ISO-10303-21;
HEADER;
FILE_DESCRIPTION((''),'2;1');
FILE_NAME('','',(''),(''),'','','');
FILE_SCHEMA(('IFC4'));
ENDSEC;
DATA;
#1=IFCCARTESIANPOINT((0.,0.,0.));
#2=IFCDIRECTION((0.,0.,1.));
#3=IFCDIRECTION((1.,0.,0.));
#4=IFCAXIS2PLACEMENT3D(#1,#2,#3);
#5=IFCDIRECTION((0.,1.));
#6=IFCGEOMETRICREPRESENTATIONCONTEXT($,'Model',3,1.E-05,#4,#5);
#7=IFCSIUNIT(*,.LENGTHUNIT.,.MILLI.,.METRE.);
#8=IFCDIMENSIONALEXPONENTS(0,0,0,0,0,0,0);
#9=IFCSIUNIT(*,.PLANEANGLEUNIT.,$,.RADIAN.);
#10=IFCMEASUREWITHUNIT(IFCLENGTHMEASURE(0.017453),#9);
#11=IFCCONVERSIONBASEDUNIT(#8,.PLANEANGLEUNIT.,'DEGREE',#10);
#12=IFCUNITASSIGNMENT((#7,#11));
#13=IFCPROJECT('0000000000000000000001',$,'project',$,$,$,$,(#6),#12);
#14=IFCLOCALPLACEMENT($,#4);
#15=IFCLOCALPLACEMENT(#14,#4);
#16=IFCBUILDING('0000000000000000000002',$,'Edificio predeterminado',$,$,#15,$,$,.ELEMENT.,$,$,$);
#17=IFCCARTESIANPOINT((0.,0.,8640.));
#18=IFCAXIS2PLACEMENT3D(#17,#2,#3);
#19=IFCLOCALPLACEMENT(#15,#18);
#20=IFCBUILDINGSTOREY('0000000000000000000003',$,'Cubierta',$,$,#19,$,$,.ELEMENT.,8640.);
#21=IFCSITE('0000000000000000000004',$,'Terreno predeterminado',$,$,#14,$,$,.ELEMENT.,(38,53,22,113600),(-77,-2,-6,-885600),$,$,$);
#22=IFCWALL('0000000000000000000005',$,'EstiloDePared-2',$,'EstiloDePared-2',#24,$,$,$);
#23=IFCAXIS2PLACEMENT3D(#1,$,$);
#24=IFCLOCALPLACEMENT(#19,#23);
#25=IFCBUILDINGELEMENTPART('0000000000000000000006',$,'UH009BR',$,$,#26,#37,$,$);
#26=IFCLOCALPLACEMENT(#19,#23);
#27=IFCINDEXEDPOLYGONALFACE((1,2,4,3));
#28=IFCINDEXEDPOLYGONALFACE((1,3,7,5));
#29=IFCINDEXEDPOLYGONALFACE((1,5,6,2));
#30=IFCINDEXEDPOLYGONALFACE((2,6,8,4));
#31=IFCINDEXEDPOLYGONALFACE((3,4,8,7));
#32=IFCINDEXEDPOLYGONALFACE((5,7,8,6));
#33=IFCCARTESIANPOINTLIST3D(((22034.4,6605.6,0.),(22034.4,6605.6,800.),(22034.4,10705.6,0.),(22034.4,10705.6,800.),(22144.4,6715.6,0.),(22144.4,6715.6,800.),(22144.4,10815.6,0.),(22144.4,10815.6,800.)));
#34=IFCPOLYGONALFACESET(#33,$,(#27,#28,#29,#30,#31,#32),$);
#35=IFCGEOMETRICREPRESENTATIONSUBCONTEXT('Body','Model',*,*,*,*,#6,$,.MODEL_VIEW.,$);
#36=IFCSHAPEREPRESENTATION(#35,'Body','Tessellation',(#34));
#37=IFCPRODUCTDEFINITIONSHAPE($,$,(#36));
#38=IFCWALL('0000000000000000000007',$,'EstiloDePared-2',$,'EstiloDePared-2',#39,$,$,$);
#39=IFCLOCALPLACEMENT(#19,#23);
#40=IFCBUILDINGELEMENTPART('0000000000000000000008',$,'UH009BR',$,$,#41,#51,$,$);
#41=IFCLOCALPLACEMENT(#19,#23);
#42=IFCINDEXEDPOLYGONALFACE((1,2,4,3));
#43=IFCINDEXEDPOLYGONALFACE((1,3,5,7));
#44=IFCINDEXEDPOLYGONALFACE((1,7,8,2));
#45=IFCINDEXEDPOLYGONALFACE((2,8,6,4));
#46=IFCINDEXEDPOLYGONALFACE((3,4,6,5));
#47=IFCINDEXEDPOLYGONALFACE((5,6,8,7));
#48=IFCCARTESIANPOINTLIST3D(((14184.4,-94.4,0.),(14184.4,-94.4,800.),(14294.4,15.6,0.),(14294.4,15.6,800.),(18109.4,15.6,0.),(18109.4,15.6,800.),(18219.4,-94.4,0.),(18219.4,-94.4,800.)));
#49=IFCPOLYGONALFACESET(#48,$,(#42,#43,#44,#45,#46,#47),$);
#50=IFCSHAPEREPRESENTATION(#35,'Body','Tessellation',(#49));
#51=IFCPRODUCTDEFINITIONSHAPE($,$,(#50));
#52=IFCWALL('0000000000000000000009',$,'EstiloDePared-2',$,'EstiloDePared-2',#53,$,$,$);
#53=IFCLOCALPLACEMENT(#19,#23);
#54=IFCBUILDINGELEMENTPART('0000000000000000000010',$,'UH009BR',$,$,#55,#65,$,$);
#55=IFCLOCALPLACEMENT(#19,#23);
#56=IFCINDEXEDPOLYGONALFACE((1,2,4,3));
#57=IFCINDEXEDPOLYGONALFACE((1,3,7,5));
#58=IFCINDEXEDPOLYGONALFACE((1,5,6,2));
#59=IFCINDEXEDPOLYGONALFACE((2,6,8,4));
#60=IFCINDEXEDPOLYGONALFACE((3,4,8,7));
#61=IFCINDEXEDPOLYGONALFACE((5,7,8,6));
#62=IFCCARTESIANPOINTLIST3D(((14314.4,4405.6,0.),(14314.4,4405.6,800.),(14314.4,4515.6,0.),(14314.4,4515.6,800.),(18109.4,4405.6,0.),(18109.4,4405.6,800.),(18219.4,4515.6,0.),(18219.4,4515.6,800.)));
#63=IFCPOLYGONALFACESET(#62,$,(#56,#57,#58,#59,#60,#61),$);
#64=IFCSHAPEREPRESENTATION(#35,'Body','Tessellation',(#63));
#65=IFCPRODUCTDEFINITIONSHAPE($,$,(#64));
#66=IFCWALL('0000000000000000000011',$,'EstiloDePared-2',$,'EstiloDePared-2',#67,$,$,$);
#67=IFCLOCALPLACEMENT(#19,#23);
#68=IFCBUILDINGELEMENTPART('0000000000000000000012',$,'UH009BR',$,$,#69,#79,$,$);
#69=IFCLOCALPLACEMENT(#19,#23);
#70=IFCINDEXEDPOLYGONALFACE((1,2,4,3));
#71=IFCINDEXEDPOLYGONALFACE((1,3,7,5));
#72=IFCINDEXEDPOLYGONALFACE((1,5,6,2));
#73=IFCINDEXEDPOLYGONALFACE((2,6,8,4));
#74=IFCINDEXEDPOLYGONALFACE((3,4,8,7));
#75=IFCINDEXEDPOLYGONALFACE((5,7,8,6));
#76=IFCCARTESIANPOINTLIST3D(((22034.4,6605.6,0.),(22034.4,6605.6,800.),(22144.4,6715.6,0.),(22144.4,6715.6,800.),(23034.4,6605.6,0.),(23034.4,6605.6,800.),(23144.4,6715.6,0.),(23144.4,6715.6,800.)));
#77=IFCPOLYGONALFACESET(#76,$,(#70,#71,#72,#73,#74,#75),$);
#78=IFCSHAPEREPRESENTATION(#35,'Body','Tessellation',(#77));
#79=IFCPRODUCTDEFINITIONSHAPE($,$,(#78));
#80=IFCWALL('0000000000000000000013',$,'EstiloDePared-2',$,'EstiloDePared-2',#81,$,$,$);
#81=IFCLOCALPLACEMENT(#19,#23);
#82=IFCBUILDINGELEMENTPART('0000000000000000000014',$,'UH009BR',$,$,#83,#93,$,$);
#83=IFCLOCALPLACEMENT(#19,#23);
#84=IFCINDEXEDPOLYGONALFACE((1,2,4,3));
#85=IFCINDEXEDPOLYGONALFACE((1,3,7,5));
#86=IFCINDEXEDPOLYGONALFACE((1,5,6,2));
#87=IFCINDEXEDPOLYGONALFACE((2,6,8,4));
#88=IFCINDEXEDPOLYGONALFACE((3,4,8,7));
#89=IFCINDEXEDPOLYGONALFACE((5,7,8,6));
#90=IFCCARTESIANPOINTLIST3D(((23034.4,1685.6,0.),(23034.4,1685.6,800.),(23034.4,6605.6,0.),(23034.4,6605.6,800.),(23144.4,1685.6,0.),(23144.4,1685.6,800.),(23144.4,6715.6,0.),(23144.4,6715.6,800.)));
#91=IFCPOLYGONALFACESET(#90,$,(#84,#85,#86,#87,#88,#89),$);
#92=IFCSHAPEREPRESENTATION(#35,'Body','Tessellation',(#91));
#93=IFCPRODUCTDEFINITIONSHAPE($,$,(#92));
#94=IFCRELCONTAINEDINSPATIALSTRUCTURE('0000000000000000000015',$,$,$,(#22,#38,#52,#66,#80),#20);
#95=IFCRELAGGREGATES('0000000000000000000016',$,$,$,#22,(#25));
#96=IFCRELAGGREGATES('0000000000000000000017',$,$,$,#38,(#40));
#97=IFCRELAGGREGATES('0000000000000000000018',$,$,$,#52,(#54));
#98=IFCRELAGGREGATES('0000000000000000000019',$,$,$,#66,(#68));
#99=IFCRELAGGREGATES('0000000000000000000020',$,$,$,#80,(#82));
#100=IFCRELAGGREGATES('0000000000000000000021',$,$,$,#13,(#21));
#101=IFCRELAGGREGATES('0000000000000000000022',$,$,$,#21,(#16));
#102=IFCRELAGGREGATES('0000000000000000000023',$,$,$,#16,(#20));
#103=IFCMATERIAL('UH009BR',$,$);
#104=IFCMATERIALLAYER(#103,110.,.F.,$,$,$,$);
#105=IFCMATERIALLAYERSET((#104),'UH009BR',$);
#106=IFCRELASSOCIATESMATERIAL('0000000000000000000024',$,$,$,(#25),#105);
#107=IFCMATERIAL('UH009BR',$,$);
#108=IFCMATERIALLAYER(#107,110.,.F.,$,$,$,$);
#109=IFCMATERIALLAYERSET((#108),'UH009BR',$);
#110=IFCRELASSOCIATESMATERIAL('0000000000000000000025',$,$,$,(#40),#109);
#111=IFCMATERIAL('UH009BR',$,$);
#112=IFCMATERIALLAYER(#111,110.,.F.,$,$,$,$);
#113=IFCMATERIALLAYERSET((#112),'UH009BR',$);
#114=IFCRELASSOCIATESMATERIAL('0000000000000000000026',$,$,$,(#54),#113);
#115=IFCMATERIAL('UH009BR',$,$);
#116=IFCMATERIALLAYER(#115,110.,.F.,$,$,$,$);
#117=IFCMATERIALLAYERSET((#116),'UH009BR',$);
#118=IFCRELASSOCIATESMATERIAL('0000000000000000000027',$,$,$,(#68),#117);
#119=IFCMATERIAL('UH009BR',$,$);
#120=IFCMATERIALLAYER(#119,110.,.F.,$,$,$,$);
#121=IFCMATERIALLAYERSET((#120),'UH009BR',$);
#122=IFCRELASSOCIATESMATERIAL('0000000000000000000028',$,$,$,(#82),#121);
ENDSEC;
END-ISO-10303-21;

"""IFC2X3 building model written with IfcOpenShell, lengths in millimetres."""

from ifc_helpers import new_model, entity, si_unit, converted_unit, direction, frame, origin_with_axes, place, context, subcontext, project, spatial, polyline, outline, extrude, material, layer, layer_set, layer_usage, element, aggregate, save


model = new_model("IFC2X3")

# Units and contexts
model_context = context("Model", 3, precision=1e-05, world=origin_with_axes(), true_north=direction((0.0, 1.0)))
body_context = subcontext(model_context, "Body", "Model", "MODEL_VIEW")
ifc_project = project(units=[si_unit("LENGTHUNIT", "METRE", prefix="MILLI"), converted_unit("PLANEANGLEUNIT", "DEGREE", entity("IfcLengthMeasure", 0.017453), si_unit("PLANEANGLEUNIT", "RADIAN"), dimensions=[0, 0, 0, 0, 0, 0, 0])], contexts=[model_context])

# Site, building, storey
site_placement = place(None, origin_with_axes())
site = spatial("IfcSite", under=ifc_project, at=site_placement, Name="Terreno predeterminado", CompositionType="ELEMENT", RefLatitude=(38, 53, 22, 113600), RefLongitude=(-77, -2, -6, -885600))
building_placement = place(site_placement, origin_with_axes())
building = spatial("IfcBuilding", under=site, at=building_placement, Name="Edificio predeterminado", CompositionType="ELEMENT")
storey_placement = place(building_placement, frame((0.0, 0.0, 8640.0), z_axis=(0.0, 0.0, 1.0), x_axis=(1.0, 0.0, 0.0)))
storey = spatial("IfcBuildingStorey", under=building, at=storey_placement, Name="Cubierta", CompositionType="ELEMENT", Elevation=8640.0)

# Wall, building element part
wall_1_placement = place(storey_placement, frame((22089.4, 10760.6, 0.0), z_axis=(0.0, 0.0, 1.0), x_axis=(0.0, -1.0, 0.0)))
wall_1 = element("IfcWall", 1, at=wall_1_placement, inside=storey, Name="EstiloDePared-2", ObjectType="EstiloDePared-2")
ifc_material_1 = material(Name="UH009BR")
ifc_layer_1 = layer(ifc_material_1, 110.0, ventilated=False)
ifc_layer_set_1 = layer_set([ifc_layer_1], Name="UH009BR")
ifc_layer_usage_1 = layer_usage(ifc_layer_set_1, "AXIS2", "NEGATIVE", -55.0)
building_element_part_1_placement = place(wall_1_placement, origin_with_axes())
building_element_part_1 = element("IfcBuildingElementPart", 2, at=building_element_part_1_placement, material=ifc_layer_usage_1, Name="UH009BR", context=body_context, shape_type="SweptSolid", body=[
    extrude(outline(polyline([(4045.0, 55.0), (4155.0, -55.0), (55.0, -55.0), (-55.0, 55.0), (4045.0, 55.0)])), origin_with_axes(), (0.0, 0.0, 1.0), 800.0),
])
aggregate(wall_1, [building_element_part_1])

# Walls, building element parts
wall_2_placement = place(storey_placement, frame((18164.4, -39.4, 0.0), z_axis=(0.0, 0.0, 1.0), x_axis=(-1.0, 0.0, 0.0)))
wall_2 = element("IfcWall", 3, at=wall_2_placement, inside=storey, Name="EstiloDePared-2", ObjectType="EstiloDePared-2")
ifc_material_2 = material(Name="UH009BR")
ifc_layer_2 = layer(ifc_material_2, 110.0, ventilated=False)
ifc_layer_set_2 = layer_set([ifc_layer_2], Name="UH009BR")
ifc_layer_usage_2 = layer_usage(ifc_layer_set_2, "AXIS2", "NEGATIVE", -55.0)
building_element_part_2_placement = place(wall_2_placement, origin_with_axes())
building_element_part_2 = element("IfcBuildingElementPart", 4, at=building_element_part_2_placement, material=ifc_layer_usage_2, Name="UH009BR", context=body_context, shape_type="SweptSolid", body=[
    extrude(outline(polyline([(3980.0, 55.0), (3870.0, -55.0), (55.0, -55.0), (-55.0, 55.0), (3980.0, 55.0)])), origin_with_axes(), (0.0, 0.0, 1.0), 800.0),
])
aggregate(wall_2, [building_element_part_2])
wall_3_placement = place(storey_placement, frame((18164.4, 4460.6, 0.0), z_axis=(0.0, 0.0, 1.0), x_axis=(-1.0, 0.0, 0.0)))
wall_3 = element("IfcWall", 5, at=wall_3_placement, inside=storey, Name="EstiloDePared-2", ObjectType="EstiloDePared-2")
ifc_material_3 = material(Name="UH009BR")
ifc_layer_3 = layer(ifc_material_3, 110.0, ventilated=False)
ifc_layer_set_3 = layer_set([ifc_layer_3], Name="UH009BR")
ifc_layer_usage_3 = layer_usage(ifc_layer_set_3, "AXIS2", "NEGATIVE", -55.0)
building_element_part_3_placement = place(wall_3_placement, origin_with_axes())
building_element_part_3 = element("IfcBuildingElementPart", 6, at=building_element_part_3_placement, material=ifc_layer_usage_3, Name="UH009BR", context=body_context, shape_type="SweptSolid", body=[
    extrude(outline(polyline([(3850.0, 55.0), (3850.0, -55.0), (-55.0, -55.0), (55.0, 55.0), (3850.0, 55.0)])), origin_with_axes(), (0.0, 0.0, 1.0), 800.0),
])
aggregate(wall_3, [building_element_part_3])
wall_4_placement = place(storey_placement, frame((22089.4, 6660.6, 0.0), z_axis=(0.0, 0.0, 1.0), x_axis=(1.0, 0.0, 0.0)))
wall_4 = element("IfcWall", 7, at=wall_4_placement, inside=storey, Name="EstiloDePared-2", ObjectType="EstiloDePared-2")
ifc_material_4 = material(Name="UH009BR")
ifc_layer_4 = layer(ifc_material_4, 110.0, ventilated=False)
ifc_layer_set_4 = layer_set([ifc_layer_4], Name="UH009BR")
ifc_layer_usage_4 = layer_usage(ifc_layer_set_4, "AXIS2", "NEGATIVE", -55.0)
building_element_part_4_placement = place(wall_4_placement, origin_with_axes())
building_element_part_4 = element("IfcBuildingElementPart", 8, at=building_element_part_4_placement, material=ifc_layer_usage_4, Name="UH009BR", context=body_context, shape_type="SweptSolid", body=[
    extrude(outline(polyline([(1055.0, 55.0), (945.0, -55.0), (-55.0, -55.0), (55.0, 55.0), (1055.0, 55.0)])), origin_with_axes(), (0.0, 0.0, 1.0), 800.0),
])
aggregate(wall_4, [building_element_part_4])
wall_5_placement = place(storey_placement, frame((23089.4, 6660.6, 0.0), z_axis=(0.0, 0.0, 1.0), x_axis=(0.0, -1.0, 0.0)))
wall_5 = element("IfcWall", 9, at=wall_5_placement, inside=storey, Name="EstiloDePared-2", ObjectType="EstiloDePared-2")
ifc_material_5 = material(Name="UH009BR")
ifc_layer_5 = layer(ifc_material_5, 110.0, ventilated=False)
ifc_layer_set_5 = layer_set([ifc_layer_5], Name="UH009BR")
ifc_layer_usage_5 = layer_usage(ifc_layer_set_5, "AXIS2", "NEGATIVE", -55.0)
building_element_part_5_placement = place(wall_5_placement, origin_with_axes())
building_element_part_5 = element("IfcBuildingElementPart", 10, at=building_element_part_5_placement, material=ifc_layer_usage_5, Name="UH009BR", context=body_context, shape_type="SweptSolid", body=[
    extrude(outline(polyline([(4975.0, 55.0), (4975.0, -55.0), (55.0, -55.0), (-55.0, 55.0), (4975.0, 55.0)])), origin_with_axes(), (0.0, 0.0, 1.0), 800.0),
])
aggregate(wall_5, [building_element_part_5])

save(model, "model.ifc")
